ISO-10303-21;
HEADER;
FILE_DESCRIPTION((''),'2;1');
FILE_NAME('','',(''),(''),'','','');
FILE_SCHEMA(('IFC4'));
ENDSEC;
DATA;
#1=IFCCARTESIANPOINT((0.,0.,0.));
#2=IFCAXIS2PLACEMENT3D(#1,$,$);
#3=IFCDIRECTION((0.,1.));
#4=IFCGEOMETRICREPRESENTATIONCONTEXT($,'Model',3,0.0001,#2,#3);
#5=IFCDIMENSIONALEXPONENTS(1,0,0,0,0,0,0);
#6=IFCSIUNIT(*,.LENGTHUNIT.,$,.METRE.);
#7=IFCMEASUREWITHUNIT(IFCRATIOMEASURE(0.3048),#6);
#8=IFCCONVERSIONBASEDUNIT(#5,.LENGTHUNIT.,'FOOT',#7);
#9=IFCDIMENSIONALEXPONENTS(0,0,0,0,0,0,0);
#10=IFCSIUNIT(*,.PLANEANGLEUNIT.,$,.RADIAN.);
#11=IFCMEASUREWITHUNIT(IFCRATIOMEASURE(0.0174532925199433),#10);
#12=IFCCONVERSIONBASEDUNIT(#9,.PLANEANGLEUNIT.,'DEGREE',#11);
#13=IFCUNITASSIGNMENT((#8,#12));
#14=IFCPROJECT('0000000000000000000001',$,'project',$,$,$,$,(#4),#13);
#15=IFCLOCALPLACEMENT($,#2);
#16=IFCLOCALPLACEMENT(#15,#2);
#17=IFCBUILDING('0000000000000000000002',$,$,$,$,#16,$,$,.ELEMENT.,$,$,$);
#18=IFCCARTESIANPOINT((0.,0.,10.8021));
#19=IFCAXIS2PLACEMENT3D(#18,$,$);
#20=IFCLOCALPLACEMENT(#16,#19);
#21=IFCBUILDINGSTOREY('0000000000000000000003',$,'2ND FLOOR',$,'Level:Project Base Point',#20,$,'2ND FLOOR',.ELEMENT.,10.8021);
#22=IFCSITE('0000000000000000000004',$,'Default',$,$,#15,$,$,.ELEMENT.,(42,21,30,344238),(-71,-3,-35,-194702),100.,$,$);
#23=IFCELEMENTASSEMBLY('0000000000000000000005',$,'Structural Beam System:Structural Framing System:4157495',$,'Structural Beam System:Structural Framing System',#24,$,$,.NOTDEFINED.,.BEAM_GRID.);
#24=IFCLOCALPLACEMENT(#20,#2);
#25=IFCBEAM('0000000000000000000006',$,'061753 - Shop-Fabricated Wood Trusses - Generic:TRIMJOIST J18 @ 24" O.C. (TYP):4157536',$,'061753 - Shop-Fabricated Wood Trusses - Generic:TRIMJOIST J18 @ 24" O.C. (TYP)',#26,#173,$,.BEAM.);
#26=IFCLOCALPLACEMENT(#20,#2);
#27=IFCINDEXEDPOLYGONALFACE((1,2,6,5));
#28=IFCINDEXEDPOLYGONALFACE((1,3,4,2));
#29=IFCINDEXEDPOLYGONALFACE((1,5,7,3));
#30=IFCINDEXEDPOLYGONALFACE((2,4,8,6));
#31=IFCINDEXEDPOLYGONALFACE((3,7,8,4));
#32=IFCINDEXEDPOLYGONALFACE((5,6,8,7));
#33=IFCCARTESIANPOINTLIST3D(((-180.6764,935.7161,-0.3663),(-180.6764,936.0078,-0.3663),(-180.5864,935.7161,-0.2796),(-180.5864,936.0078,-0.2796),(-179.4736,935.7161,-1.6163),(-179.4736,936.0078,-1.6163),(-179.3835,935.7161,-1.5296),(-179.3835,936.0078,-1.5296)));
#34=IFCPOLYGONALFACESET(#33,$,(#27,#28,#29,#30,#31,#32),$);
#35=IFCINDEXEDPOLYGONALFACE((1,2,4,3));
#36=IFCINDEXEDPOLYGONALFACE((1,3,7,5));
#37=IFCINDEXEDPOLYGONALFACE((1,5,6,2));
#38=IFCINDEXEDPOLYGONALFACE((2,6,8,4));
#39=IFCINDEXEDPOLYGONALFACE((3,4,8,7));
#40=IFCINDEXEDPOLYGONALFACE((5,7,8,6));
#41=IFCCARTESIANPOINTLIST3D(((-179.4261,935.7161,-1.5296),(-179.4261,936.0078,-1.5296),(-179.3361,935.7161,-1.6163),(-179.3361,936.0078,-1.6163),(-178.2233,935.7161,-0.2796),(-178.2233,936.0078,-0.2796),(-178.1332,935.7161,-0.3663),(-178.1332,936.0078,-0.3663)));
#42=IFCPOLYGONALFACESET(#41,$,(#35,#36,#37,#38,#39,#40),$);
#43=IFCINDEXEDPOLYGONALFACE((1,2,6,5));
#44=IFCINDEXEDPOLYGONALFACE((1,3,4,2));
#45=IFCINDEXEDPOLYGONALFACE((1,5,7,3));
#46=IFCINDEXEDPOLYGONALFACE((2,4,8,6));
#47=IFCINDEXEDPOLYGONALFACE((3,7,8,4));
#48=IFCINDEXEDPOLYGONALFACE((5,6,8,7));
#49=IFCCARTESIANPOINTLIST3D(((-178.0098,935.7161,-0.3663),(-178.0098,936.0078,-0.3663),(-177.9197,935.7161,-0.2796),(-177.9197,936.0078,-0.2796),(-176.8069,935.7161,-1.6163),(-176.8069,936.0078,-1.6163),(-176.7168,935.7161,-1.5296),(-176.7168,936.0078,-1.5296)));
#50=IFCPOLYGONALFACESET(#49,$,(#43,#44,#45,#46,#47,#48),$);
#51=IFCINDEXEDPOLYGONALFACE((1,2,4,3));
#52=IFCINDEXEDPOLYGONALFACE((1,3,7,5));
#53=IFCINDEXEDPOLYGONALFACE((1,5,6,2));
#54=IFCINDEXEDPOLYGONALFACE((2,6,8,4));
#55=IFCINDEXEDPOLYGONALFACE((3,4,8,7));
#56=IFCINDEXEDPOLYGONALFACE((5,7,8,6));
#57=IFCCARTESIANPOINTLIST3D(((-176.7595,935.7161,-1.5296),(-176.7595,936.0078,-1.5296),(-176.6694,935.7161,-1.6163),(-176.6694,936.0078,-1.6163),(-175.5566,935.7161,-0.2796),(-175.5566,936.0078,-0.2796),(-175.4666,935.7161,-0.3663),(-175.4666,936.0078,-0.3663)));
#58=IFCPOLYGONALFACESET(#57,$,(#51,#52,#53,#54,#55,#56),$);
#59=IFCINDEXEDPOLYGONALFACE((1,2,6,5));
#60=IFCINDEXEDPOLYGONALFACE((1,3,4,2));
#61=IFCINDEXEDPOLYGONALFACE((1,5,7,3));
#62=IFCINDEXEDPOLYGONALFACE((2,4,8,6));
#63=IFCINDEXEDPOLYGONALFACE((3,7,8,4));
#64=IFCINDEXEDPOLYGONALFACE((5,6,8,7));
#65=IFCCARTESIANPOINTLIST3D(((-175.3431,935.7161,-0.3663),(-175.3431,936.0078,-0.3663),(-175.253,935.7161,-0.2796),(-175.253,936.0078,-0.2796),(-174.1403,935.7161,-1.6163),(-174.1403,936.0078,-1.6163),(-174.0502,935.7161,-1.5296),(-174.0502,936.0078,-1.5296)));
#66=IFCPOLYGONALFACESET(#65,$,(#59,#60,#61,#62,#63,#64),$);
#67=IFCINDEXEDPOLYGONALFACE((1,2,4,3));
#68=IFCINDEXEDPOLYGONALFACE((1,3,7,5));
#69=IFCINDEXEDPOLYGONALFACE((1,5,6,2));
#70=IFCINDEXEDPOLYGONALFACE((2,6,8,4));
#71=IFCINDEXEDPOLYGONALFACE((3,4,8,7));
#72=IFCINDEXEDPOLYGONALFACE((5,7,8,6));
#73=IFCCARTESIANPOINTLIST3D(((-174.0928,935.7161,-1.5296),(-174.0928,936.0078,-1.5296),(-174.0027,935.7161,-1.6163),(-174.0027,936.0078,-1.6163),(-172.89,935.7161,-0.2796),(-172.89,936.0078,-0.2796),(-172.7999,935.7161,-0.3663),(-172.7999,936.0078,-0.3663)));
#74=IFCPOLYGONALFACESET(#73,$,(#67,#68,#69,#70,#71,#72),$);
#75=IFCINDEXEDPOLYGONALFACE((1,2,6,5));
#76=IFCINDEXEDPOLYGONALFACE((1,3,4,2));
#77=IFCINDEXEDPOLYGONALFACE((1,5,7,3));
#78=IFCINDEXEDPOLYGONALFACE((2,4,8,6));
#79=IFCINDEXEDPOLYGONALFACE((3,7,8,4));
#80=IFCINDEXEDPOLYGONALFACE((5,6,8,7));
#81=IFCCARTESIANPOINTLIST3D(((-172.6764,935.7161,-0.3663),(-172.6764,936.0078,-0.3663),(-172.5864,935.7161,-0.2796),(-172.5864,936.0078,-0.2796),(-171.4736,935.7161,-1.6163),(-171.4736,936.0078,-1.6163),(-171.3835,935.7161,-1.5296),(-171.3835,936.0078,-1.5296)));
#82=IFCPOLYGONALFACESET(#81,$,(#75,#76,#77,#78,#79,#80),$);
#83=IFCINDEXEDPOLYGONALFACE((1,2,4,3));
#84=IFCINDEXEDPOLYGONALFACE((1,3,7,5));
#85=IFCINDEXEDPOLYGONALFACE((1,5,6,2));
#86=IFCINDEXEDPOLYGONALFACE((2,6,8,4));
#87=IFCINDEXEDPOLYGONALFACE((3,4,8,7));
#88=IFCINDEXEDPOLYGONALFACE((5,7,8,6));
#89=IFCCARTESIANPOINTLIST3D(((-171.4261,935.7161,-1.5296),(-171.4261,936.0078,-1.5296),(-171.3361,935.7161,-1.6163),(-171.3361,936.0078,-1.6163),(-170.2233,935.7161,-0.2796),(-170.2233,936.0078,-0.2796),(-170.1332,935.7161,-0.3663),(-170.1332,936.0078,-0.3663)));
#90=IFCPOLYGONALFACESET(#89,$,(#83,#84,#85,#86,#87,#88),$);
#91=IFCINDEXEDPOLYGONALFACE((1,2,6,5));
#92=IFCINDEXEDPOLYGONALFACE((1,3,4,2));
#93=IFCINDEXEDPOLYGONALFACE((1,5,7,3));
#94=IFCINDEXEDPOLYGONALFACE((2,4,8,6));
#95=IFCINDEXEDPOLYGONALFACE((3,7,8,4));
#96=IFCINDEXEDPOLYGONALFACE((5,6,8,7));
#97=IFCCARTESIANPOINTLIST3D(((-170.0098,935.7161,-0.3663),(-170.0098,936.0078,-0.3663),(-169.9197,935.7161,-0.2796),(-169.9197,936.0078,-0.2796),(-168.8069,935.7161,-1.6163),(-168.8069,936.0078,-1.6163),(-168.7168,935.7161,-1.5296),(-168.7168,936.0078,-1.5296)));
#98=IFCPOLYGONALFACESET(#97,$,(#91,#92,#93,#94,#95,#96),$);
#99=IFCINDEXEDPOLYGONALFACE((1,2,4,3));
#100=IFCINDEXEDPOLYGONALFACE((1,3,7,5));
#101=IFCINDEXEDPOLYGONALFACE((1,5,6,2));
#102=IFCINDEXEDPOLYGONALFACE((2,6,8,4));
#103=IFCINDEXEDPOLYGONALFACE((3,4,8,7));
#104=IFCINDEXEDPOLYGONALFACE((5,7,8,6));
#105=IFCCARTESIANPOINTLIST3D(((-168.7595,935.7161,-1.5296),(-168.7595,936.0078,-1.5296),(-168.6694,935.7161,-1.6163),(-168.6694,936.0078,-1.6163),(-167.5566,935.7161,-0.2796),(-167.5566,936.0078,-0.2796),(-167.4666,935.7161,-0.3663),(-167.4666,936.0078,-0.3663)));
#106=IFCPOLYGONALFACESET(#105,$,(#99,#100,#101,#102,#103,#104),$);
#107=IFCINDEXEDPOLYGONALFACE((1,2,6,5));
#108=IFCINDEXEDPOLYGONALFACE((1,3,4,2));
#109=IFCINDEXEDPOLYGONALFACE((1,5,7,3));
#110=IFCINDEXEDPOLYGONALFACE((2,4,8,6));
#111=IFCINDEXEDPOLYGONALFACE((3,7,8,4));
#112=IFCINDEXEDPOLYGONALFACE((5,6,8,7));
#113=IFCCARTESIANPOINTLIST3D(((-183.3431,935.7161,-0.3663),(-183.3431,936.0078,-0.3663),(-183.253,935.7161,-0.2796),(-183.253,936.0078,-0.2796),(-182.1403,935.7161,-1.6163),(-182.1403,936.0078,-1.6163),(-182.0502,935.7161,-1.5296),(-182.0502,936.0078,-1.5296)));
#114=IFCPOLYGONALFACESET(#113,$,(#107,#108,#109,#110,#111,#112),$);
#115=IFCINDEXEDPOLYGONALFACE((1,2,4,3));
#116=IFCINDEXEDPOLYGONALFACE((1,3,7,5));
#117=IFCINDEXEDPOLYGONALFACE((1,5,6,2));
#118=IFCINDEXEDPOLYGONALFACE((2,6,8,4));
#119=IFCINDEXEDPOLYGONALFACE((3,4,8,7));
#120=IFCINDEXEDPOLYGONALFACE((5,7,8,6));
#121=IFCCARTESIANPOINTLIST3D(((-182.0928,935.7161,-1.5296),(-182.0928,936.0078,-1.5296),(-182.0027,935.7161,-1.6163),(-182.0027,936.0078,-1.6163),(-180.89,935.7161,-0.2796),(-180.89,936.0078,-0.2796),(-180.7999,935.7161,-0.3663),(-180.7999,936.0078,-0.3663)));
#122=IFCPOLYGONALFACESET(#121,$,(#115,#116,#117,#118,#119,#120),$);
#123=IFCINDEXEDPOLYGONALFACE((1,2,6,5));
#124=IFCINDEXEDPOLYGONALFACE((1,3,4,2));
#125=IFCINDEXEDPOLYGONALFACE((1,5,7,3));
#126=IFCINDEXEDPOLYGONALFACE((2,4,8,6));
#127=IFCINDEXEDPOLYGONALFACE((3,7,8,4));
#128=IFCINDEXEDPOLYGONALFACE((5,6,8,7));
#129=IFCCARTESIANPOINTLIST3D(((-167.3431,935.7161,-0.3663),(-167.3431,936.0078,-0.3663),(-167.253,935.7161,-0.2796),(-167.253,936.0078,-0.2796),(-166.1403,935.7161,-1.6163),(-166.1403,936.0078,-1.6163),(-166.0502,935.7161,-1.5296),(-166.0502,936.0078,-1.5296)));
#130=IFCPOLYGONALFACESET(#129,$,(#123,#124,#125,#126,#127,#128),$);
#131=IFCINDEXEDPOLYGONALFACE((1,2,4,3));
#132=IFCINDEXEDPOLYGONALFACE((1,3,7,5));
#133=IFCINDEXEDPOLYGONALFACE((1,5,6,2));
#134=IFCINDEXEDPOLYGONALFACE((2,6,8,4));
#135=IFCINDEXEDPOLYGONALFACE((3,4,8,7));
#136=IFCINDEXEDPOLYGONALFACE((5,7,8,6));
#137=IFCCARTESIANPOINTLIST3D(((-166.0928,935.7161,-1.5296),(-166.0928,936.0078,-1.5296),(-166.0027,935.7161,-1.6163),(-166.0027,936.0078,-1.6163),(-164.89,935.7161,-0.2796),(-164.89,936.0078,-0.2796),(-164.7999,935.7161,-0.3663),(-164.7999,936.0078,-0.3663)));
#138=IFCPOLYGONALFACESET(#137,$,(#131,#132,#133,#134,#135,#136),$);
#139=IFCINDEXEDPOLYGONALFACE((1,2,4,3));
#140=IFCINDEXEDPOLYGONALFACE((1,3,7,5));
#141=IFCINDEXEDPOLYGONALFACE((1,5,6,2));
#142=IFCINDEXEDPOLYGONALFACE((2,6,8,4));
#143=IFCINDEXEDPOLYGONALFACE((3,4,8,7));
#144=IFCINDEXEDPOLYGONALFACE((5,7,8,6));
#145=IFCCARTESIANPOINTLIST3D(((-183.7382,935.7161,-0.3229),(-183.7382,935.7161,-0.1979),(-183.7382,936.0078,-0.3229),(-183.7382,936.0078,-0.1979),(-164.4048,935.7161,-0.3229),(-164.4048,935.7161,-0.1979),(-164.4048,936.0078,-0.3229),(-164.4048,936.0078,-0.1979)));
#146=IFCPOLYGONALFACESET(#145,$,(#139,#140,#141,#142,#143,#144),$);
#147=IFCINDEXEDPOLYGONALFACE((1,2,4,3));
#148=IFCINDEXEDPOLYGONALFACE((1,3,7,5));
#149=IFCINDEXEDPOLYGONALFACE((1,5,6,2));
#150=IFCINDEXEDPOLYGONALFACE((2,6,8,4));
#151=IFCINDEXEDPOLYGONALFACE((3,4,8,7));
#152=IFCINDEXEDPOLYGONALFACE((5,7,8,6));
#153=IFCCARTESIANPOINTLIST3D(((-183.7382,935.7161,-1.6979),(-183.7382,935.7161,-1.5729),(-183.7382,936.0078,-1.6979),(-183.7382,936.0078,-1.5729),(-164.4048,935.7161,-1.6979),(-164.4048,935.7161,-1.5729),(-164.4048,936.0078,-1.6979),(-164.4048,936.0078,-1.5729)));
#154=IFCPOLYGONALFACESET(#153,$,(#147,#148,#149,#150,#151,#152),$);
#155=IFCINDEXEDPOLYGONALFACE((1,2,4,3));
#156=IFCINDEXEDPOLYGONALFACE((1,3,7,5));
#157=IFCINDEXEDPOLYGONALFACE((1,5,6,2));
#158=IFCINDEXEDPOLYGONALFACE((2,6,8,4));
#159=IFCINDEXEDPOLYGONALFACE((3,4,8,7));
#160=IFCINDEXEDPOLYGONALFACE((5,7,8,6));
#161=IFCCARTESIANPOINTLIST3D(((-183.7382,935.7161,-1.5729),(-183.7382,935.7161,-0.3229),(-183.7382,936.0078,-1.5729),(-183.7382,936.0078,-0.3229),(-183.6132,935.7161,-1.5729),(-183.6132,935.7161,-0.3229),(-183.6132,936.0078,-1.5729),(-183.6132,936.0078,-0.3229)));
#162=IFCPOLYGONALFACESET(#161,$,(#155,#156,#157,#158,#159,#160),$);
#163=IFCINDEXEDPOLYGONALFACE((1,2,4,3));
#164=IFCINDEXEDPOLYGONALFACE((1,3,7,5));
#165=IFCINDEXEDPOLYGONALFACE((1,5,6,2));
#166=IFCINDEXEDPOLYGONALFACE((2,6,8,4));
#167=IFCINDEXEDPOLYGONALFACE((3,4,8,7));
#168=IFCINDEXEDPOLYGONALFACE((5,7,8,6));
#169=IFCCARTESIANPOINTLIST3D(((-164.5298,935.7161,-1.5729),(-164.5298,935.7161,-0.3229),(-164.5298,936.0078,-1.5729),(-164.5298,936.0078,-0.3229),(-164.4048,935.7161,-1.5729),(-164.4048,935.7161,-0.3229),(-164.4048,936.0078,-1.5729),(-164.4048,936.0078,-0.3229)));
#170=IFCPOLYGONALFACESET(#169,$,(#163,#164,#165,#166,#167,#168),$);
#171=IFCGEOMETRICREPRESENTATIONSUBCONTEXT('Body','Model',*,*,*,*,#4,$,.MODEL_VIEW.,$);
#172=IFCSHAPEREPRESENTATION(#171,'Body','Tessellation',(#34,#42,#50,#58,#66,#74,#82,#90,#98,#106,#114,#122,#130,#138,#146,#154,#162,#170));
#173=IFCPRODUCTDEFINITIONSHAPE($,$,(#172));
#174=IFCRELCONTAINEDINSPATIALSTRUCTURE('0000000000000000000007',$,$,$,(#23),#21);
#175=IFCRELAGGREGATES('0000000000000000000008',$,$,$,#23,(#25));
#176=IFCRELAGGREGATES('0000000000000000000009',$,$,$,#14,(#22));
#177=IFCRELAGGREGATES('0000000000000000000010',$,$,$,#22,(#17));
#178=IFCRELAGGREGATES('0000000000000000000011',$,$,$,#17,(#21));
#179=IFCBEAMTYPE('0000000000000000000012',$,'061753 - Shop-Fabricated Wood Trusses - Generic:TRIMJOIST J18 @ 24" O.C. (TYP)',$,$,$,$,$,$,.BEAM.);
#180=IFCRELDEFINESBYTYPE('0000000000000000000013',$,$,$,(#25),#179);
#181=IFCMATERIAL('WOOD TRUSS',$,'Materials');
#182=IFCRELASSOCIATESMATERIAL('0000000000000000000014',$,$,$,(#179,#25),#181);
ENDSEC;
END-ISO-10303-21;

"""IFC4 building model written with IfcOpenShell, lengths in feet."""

from ifc_helpers import new_model, entity, si_unit, converted_unit, direction, frame, frame_2d, origin, origin_2d_with_axis, place, context, subcontext, project, spatial, rectangle, extrude, source, transform, mapped, material, material_profile, profile_set, profile_usage, type_object, type_shapes, element, aggregate, save


model = new_model("IFC4")

# Units and contexts
model_context = context("Model", 3, precision=0.0001, world=origin(), true_north=direction((0.0, 1.0)))
body_context = subcontext(model_context, "Body", "Model", "MODEL_VIEW")
ifc_project = project(units=[converted_unit("LENGTHUNIT", "FOOT", entity("IfcRatioMeasure", 0.3048), si_unit("LENGTHUNIT", "METRE"), dimensions=[1, 0, 0, 0, 0, 0, 0]), converted_unit("PLANEANGLEUNIT", "DEGREE", entity("IfcRatioMeasure", 0.0174532925199433), si_unit("PLANEANGLEUNIT", "RADIAN"), dimensions=[0, 0, 0, 0, 0, 0, 0])], contexts=[model_context])

# Site, building, storey
site_placement = place(None, origin())
site = spatial("IfcSite", under=ifc_project, at=site_placement, Name="Default", CompositionType="ELEMENT", RefLatitude=(42, 21, 30, 344238), RefLongitude=(-71, -3, -35, -194702), RefElevation=100.0)
building_placement = place(site_placement, origin())
building = spatial("IfcBuilding", under=site, at=building_placement, CompositionType="ELEMENT")
storey_placement = place(building_placement, frame((0.0, 0.0, 10.8021)))
storey = spatial("IfcBuildingStorey", under=building, at=storey_placement, Name="2ND FLOOR", ObjectType="Level:Project Base Point", LongName="2ND FLOOR", CompositionType="ELEMENT", Elevation=10.8021)

# Element assembly, beam
ifc_material_1 = material(Name="WOOD TRUSS", Category="Materials")
ifc_material_profile_1 = material_profile(ifc_material_1, rectangle(XDim=1.7347, YDim=0.125, at=frame_2d((0.0, 0.0), x_axis=(1.0, 0.0))), Name="TRIMJOIST J18 @ 24\" O.C. (TYP)")
ifc_material_profile_2 = material_profile(ifc_material_1, rectangle(XDim=1.7347, YDim=0.125, at=frame_2d((0.0, 0.0), x_axis=(1.0, 0.0))), Name="TRIMJOIST J18 @ 24\" O.C. (TYP)")
ifc_material_profile_3 = material_profile(ifc_material_1, rectangle(XDim=1.7347, YDim=0.125, at=frame_2d((0.0, 0.0), x_axis=(1.0, 0.0))), Name="TRIMJOIST J18 @ 24\" O.C. (TYP)")
ifc_material_profile_4 = material_profile(ifc_material_1, rectangle(XDim=1.7347, YDim=0.125, at=frame_2d((0.0, 0.0), x_axis=(1.0, 0.0))), Name="TRIMJOIST J18 @ 24\" O.C. (TYP)")
ifc_material_profile_5 = material_profile(ifc_material_1, rectangle(XDim=1.7347, YDim=0.125, at=frame_2d((0.0, 0.0), x_axis=(1.0, 0.0))), Name="TRIMJOIST J18 @ 24\" O.C. (TYP)")
ifc_material_profile_6 = material_profile(ifc_material_1, rectangle(XDim=1.7347, YDim=0.125, at=frame_2d((0.0, 0.0), x_axis=(1.0, 0.0))), Name="TRIMJOIST J18 @ 24\" O.C. (TYP)")
ifc_material_profile_7 = material_profile(ifc_material_1, rectangle(XDim=1.7347, YDim=0.125, at=frame_2d((0.0, 0.0), x_axis=(1.0, 0.0))), Name="TRIMJOIST J18 @ 24\" O.C. (TYP)")
ifc_material_profile_8 = material_profile(ifc_material_1, rectangle(XDim=1.7347, YDim=0.125, at=frame_2d((0.0, 0.0), x_axis=(1.0, 0.0))), Name="TRIMJOIST J18 @ 24\" O.C. (TYP)")
ifc_material_profile_9 = material_profile(ifc_material_1, rectangle(XDim=1.7347, YDim=0.125, at=frame_2d((0.0, 0.0), x_axis=(1.0, 0.0))), Name="TRIMJOIST J18 @ 24\" O.C. (TYP)")
ifc_material_profile_10 = material_profile(ifc_material_1, rectangle(XDim=1.7347, YDim=0.125, at=origin_2d_with_axis()), Name="TRIMJOIST J18 @ 24\" O.C. (TYP)")
ifc_material_profile_11 = material_profile(ifc_material_1, rectangle(XDim=0.125, YDim=0.2917, at=origin_2d_with_axis()), Name="TRIMJOIST J18 @ 24\" O.C. (TYP)")
ifc_material_profile_12 = material_profile(ifc_material_1, rectangle(XDim=0.125, YDim=0.2917, at=origin_2d_with_axis()), Name="TRIMJOIST J18 @ 24\" O.C. (TYP)")
ifc_material_profile_13 = material_profile(ifc_material_1, rectangle(XDim=1.25, YDim=0.2917, at=origin_2d_with_axis()), Name="TRIMJOIST J18 @ 24\" O.C. (TYP)")
ifc_material_profile_14 = material_profile(ifc_material_1, rectangle(XDim=1.25, YDim=0.2917, at=origin_2d_with_axis()), Name="TRIMJOIST J18 @ 24\" O.C. (TYP)")
ifc_profile_set_1 = profile_set([ifc_material_profile_1, ifc_material_profile_2, ifc_material_profile_3, ifc_material_profile_4, ifc_material_profile_5, ifc_material_profile_6, ifc_material_profile_7, ifc_material_profile_8, ifc_material_profile_9, ifc_material_profile_10, ifc_material_profile_11, ifc_material_profile_12, ifc_material_profile_13, ifc_material_profile_14], Name="TRIMJOIST J18 @ 24\" O.C. (TYP)")
assembly_1_placement = place(storey_placement, origin())
assembly_1 = element("IfcElementAssembly", 1, at=assembly_1_placement, inside=storey, Name="Structural Beam System:Structural Framing System:4157495", ObjectType="Structural Beam System:Structural Framing System", AssemblyPlace="NOTDEFINED", PredefinedType="BEAM_GRID")
beam_type_1 = type_object("IfcBeamType", Name="061753 - Shop-Fabricated Wood Trusses - Generic:TRIMJOIST J18 @ 24\" O.C. (TYP)", PredefinedType="BEAM", material=ifc_profile_set_1)
shared_shape_1 = source(origin(), body_context, "Body", "SweptSolid", [
    extrude(rectangle(XDim=1.7347, YDim=0.125, at=frame_2d((0.0, 0.0), x_axis=(1.0, 0.0))), frame((5.9585, -0.1458, 0.0), z_axis=(0.0, 1.0, 0.0), x_axis=(0.693383, 0.0, 0.720569)), (0.0, 0.0, 1.0), 0.2917),
    extrude(rectangle(XDim=1.7347, YDim=0.125, at=origin_2d_with_axis()), frame((4.7082, -0.1458, 0.0), z_axis=(0.0, 1.0, 0.0), x_axis=(0.693383, 0.0, -0.720569)), (0.0, 0.0, 1.0), 0.2917),
    extrude(rectangle(XDim=1.7347, YDim=0.125, at=frame_2d((0.0, 0.0), x_axis=(1.0, 0.0))), frame((3.2918, -0.1458, 0.0), z_axis=(0.0, 1.0, 0.0), x_axis=(0.693383, 0.0, 0.720569)), (0.0, 0.0, 1.0), 0.2917),
    extrude(rectangle(XDim=1.7347, YDim=0.125, at=frame_2d((0.0, 0.0), x_axis=(1.0, 0.0))), frame((2.0415, -0.1458, 0.0), z_axis=(0.0, 1.0, 0.0), x_axis=(0.693383, 0.0, -0.720569)), (0.0, 0.0, 1.0), 0.2917),
    extrude(rectangle(XDim=1.7347, YDim=0.125, at=frame_2d((0.0, 0.0), x_axis=(1.0, 0.0))), frame((0.6251, -0.1458, 0.0), z_axis=(0.0, 1.0, 0.0), x_axis=(0.693383, 0.0, 0.720569)), (0.0, 0.0, 1.0), 0.2917),
    extrude(rectangle(XDim=1.7347, YDim=0.125, at=frame_2d((0.0, 0.0), x_axis=(1.0, 0.0))), frame((-0.6251, -0.1458, 0.0), z_axis=(0.0, 1.0, 0.0), x_axis=(0.693383, 0.0, -0.720569)), (0.0, 0.0, 1.0), 0.2917),
    extrude(rectangle(XDim=1.7347, YDim=0.125, at=frame_2d((0.0, 0.0), x_axis=(1.0, 0.0))), frame((-2.0415, -0.1458, 0.0), z_axis=(0.0, 1.0, 0.0), x_axis=(0.693383, 0.0, 0.720569)), (0.0, 0.0, 1.0), 0.2917),
    extrude(rectangle(XDim=1.7347, YDim=0.125, at=origin_2d_with_axis()), frame((-3.2918, -0.1458, 0.0), z_axis=(0.0, 1.0, 0.0), x_axis=(0.693383, 0.0, -0.720569)), (0.0, 0.0, 1.0), 0.2917),
    extrude(rectangle(XDim=1.7347, YDim=0.125, at=frame_2d((0.0, 0.0), x_axis=(1.0, 0.0))), frame((-4.7082, -0.1458, 0.0), z_axis=(0.0, 1.0, 0.0), x_axis=(0.693383, 0.0, 0.720569)), (0.0, 0.0, 1.0), 0.2917),
    extrude(rectangle(XDim=1.7347, YDim=0.125, at=frame_2d((0.0, 0.0), x_axis=(1.0, 0.0))), frame((-5.9585, -0.1458, 0.0), z_axis=(0.0, 1.0, 0.0), x_axis=(0.693383, 0.0, -0.720569)), (0.0, 0.0, 1.0), 0.2917),
    extrude(rectangle(XDim=1.7347, YDim=0.125, at=frame_2d((0.0, 0.0), x_axis=(1.0, 0.0))), frame((8.6251, -0.1458, 0.0), z_axis=(0.0, 1.0, 0.0), x_axis=(0.693383, 0.0, 0.720569)), (0.0, 0.0, 1.0), 0.2917),
    extrude(rectangle(XDim=1.7347, YDim=0.125, at=origin_2d_with_axis()), frame((7.3749, -0.1458, 0.0), z_axis=(0.0, 1.0, 0.0), x_axis=(0.693383, 0.0, -0.720569)), (0.0, 0.0, 1.0), 0.2917),
    extrude(rectangle(XDim=1.7347, YDim=0.125, at=frame_2d((0.0, 0.0), x_axis=(1.0, 0.0))), frame((-7.3749, -0.1458, 0.0), z_axis=(0.0, 1.0, 0.0), x_axis=(0.693383, 0.0, 0.720569)), (0.0, 0.0, 1.0), 0.2917),
    extrude(rectangle(XDim=1.7347, YDim=0.125, at=origin_2d_with_axis()), frame((-8.6251, -0.1458, 0.0), z_axis=(0.0, 1.0, 0.0), x_axis=(0.693383, 0.0, -0.720569)), (0.0, 0.0, 1.0), 0.2917),
    extrude(rectangle(XDim=0.125, YDim=0.2917, at=origin_2d_with_axis()), frame((-9.6667, 0.0, 0.6875), z_axis=(1.0, 0.0, 0.0), x_axis=(0.0, 0.0, -1.0)), (0.0, 0.0, 1.0), 19.3333),
    extrude(rectangle(XDim=0.125, YDim=0.2917, at=origin_2d_with_axis()), frame((-9.6667, 0.0, -0.6875), z_axis=(1.0, 0.0, 0.0), x_axis=(0.0, 0.0, -1.0)), (0.0, 0.0, 1.0), 19.3333),
    extrude(rectangle(XDim=1.25, YDim=0.2917, at=origin_2d_with_axis()), frame((9.5417, 0.0, 0.0), z_axis=(1.0, 0.0, 0.0), x_axis=(0.0, 0.0, -1.0)), (0.0, 0.0, 1.0), 0.125),
    extrude(rectangle(XDim=1.25, YDim=0.2917, at=origin_2d_with_axis()), frame((-9.6667, 0.0, 0.0), z_axis=(1.0, 0.0, 0.0), x_axis=(0.0, 0.0, -1.0)), (0.0, 0.0, 1.0), 0.125),
])
type_shapes(beam_type_1, [shared_shape_1])
ifc_profile_usage_1 = profile_usage(ifc_profile_set_1, cardinal=8)
beam_1_placement = place(assembly_1_placement, frame((-174.0715, 935.8619, -0.9479), z_axis=(0.0, 0.0, 1.0), x_axis=(-1.0, 0.0, 0.0)))
beam_1 = element("IfcBeam", 2, at=beam_1_placement, type_object=beam_type_1, material=ifc_profile_usage_1, Name="061753 - Shop-Fabricated Wood Trusses - Generic:TRIMJOIST J18 @ 24\" O.C. (TYP):4157536", ObjectType="061753 - Shop-Fabricated Wood Trusses - Generic:TRIMJOIST J18 @ 24\" O.C. (TYP)", PredefinedType="BEAM", context=body_context, shape_type="MappedRepresentation", body=[
    mapped(shared_shape_1, transform((0.0, 0.0, 0.0), scale=1.0)),
])
aggregate(assembly_1, [beam_1])

save(model, "model.ifc")
